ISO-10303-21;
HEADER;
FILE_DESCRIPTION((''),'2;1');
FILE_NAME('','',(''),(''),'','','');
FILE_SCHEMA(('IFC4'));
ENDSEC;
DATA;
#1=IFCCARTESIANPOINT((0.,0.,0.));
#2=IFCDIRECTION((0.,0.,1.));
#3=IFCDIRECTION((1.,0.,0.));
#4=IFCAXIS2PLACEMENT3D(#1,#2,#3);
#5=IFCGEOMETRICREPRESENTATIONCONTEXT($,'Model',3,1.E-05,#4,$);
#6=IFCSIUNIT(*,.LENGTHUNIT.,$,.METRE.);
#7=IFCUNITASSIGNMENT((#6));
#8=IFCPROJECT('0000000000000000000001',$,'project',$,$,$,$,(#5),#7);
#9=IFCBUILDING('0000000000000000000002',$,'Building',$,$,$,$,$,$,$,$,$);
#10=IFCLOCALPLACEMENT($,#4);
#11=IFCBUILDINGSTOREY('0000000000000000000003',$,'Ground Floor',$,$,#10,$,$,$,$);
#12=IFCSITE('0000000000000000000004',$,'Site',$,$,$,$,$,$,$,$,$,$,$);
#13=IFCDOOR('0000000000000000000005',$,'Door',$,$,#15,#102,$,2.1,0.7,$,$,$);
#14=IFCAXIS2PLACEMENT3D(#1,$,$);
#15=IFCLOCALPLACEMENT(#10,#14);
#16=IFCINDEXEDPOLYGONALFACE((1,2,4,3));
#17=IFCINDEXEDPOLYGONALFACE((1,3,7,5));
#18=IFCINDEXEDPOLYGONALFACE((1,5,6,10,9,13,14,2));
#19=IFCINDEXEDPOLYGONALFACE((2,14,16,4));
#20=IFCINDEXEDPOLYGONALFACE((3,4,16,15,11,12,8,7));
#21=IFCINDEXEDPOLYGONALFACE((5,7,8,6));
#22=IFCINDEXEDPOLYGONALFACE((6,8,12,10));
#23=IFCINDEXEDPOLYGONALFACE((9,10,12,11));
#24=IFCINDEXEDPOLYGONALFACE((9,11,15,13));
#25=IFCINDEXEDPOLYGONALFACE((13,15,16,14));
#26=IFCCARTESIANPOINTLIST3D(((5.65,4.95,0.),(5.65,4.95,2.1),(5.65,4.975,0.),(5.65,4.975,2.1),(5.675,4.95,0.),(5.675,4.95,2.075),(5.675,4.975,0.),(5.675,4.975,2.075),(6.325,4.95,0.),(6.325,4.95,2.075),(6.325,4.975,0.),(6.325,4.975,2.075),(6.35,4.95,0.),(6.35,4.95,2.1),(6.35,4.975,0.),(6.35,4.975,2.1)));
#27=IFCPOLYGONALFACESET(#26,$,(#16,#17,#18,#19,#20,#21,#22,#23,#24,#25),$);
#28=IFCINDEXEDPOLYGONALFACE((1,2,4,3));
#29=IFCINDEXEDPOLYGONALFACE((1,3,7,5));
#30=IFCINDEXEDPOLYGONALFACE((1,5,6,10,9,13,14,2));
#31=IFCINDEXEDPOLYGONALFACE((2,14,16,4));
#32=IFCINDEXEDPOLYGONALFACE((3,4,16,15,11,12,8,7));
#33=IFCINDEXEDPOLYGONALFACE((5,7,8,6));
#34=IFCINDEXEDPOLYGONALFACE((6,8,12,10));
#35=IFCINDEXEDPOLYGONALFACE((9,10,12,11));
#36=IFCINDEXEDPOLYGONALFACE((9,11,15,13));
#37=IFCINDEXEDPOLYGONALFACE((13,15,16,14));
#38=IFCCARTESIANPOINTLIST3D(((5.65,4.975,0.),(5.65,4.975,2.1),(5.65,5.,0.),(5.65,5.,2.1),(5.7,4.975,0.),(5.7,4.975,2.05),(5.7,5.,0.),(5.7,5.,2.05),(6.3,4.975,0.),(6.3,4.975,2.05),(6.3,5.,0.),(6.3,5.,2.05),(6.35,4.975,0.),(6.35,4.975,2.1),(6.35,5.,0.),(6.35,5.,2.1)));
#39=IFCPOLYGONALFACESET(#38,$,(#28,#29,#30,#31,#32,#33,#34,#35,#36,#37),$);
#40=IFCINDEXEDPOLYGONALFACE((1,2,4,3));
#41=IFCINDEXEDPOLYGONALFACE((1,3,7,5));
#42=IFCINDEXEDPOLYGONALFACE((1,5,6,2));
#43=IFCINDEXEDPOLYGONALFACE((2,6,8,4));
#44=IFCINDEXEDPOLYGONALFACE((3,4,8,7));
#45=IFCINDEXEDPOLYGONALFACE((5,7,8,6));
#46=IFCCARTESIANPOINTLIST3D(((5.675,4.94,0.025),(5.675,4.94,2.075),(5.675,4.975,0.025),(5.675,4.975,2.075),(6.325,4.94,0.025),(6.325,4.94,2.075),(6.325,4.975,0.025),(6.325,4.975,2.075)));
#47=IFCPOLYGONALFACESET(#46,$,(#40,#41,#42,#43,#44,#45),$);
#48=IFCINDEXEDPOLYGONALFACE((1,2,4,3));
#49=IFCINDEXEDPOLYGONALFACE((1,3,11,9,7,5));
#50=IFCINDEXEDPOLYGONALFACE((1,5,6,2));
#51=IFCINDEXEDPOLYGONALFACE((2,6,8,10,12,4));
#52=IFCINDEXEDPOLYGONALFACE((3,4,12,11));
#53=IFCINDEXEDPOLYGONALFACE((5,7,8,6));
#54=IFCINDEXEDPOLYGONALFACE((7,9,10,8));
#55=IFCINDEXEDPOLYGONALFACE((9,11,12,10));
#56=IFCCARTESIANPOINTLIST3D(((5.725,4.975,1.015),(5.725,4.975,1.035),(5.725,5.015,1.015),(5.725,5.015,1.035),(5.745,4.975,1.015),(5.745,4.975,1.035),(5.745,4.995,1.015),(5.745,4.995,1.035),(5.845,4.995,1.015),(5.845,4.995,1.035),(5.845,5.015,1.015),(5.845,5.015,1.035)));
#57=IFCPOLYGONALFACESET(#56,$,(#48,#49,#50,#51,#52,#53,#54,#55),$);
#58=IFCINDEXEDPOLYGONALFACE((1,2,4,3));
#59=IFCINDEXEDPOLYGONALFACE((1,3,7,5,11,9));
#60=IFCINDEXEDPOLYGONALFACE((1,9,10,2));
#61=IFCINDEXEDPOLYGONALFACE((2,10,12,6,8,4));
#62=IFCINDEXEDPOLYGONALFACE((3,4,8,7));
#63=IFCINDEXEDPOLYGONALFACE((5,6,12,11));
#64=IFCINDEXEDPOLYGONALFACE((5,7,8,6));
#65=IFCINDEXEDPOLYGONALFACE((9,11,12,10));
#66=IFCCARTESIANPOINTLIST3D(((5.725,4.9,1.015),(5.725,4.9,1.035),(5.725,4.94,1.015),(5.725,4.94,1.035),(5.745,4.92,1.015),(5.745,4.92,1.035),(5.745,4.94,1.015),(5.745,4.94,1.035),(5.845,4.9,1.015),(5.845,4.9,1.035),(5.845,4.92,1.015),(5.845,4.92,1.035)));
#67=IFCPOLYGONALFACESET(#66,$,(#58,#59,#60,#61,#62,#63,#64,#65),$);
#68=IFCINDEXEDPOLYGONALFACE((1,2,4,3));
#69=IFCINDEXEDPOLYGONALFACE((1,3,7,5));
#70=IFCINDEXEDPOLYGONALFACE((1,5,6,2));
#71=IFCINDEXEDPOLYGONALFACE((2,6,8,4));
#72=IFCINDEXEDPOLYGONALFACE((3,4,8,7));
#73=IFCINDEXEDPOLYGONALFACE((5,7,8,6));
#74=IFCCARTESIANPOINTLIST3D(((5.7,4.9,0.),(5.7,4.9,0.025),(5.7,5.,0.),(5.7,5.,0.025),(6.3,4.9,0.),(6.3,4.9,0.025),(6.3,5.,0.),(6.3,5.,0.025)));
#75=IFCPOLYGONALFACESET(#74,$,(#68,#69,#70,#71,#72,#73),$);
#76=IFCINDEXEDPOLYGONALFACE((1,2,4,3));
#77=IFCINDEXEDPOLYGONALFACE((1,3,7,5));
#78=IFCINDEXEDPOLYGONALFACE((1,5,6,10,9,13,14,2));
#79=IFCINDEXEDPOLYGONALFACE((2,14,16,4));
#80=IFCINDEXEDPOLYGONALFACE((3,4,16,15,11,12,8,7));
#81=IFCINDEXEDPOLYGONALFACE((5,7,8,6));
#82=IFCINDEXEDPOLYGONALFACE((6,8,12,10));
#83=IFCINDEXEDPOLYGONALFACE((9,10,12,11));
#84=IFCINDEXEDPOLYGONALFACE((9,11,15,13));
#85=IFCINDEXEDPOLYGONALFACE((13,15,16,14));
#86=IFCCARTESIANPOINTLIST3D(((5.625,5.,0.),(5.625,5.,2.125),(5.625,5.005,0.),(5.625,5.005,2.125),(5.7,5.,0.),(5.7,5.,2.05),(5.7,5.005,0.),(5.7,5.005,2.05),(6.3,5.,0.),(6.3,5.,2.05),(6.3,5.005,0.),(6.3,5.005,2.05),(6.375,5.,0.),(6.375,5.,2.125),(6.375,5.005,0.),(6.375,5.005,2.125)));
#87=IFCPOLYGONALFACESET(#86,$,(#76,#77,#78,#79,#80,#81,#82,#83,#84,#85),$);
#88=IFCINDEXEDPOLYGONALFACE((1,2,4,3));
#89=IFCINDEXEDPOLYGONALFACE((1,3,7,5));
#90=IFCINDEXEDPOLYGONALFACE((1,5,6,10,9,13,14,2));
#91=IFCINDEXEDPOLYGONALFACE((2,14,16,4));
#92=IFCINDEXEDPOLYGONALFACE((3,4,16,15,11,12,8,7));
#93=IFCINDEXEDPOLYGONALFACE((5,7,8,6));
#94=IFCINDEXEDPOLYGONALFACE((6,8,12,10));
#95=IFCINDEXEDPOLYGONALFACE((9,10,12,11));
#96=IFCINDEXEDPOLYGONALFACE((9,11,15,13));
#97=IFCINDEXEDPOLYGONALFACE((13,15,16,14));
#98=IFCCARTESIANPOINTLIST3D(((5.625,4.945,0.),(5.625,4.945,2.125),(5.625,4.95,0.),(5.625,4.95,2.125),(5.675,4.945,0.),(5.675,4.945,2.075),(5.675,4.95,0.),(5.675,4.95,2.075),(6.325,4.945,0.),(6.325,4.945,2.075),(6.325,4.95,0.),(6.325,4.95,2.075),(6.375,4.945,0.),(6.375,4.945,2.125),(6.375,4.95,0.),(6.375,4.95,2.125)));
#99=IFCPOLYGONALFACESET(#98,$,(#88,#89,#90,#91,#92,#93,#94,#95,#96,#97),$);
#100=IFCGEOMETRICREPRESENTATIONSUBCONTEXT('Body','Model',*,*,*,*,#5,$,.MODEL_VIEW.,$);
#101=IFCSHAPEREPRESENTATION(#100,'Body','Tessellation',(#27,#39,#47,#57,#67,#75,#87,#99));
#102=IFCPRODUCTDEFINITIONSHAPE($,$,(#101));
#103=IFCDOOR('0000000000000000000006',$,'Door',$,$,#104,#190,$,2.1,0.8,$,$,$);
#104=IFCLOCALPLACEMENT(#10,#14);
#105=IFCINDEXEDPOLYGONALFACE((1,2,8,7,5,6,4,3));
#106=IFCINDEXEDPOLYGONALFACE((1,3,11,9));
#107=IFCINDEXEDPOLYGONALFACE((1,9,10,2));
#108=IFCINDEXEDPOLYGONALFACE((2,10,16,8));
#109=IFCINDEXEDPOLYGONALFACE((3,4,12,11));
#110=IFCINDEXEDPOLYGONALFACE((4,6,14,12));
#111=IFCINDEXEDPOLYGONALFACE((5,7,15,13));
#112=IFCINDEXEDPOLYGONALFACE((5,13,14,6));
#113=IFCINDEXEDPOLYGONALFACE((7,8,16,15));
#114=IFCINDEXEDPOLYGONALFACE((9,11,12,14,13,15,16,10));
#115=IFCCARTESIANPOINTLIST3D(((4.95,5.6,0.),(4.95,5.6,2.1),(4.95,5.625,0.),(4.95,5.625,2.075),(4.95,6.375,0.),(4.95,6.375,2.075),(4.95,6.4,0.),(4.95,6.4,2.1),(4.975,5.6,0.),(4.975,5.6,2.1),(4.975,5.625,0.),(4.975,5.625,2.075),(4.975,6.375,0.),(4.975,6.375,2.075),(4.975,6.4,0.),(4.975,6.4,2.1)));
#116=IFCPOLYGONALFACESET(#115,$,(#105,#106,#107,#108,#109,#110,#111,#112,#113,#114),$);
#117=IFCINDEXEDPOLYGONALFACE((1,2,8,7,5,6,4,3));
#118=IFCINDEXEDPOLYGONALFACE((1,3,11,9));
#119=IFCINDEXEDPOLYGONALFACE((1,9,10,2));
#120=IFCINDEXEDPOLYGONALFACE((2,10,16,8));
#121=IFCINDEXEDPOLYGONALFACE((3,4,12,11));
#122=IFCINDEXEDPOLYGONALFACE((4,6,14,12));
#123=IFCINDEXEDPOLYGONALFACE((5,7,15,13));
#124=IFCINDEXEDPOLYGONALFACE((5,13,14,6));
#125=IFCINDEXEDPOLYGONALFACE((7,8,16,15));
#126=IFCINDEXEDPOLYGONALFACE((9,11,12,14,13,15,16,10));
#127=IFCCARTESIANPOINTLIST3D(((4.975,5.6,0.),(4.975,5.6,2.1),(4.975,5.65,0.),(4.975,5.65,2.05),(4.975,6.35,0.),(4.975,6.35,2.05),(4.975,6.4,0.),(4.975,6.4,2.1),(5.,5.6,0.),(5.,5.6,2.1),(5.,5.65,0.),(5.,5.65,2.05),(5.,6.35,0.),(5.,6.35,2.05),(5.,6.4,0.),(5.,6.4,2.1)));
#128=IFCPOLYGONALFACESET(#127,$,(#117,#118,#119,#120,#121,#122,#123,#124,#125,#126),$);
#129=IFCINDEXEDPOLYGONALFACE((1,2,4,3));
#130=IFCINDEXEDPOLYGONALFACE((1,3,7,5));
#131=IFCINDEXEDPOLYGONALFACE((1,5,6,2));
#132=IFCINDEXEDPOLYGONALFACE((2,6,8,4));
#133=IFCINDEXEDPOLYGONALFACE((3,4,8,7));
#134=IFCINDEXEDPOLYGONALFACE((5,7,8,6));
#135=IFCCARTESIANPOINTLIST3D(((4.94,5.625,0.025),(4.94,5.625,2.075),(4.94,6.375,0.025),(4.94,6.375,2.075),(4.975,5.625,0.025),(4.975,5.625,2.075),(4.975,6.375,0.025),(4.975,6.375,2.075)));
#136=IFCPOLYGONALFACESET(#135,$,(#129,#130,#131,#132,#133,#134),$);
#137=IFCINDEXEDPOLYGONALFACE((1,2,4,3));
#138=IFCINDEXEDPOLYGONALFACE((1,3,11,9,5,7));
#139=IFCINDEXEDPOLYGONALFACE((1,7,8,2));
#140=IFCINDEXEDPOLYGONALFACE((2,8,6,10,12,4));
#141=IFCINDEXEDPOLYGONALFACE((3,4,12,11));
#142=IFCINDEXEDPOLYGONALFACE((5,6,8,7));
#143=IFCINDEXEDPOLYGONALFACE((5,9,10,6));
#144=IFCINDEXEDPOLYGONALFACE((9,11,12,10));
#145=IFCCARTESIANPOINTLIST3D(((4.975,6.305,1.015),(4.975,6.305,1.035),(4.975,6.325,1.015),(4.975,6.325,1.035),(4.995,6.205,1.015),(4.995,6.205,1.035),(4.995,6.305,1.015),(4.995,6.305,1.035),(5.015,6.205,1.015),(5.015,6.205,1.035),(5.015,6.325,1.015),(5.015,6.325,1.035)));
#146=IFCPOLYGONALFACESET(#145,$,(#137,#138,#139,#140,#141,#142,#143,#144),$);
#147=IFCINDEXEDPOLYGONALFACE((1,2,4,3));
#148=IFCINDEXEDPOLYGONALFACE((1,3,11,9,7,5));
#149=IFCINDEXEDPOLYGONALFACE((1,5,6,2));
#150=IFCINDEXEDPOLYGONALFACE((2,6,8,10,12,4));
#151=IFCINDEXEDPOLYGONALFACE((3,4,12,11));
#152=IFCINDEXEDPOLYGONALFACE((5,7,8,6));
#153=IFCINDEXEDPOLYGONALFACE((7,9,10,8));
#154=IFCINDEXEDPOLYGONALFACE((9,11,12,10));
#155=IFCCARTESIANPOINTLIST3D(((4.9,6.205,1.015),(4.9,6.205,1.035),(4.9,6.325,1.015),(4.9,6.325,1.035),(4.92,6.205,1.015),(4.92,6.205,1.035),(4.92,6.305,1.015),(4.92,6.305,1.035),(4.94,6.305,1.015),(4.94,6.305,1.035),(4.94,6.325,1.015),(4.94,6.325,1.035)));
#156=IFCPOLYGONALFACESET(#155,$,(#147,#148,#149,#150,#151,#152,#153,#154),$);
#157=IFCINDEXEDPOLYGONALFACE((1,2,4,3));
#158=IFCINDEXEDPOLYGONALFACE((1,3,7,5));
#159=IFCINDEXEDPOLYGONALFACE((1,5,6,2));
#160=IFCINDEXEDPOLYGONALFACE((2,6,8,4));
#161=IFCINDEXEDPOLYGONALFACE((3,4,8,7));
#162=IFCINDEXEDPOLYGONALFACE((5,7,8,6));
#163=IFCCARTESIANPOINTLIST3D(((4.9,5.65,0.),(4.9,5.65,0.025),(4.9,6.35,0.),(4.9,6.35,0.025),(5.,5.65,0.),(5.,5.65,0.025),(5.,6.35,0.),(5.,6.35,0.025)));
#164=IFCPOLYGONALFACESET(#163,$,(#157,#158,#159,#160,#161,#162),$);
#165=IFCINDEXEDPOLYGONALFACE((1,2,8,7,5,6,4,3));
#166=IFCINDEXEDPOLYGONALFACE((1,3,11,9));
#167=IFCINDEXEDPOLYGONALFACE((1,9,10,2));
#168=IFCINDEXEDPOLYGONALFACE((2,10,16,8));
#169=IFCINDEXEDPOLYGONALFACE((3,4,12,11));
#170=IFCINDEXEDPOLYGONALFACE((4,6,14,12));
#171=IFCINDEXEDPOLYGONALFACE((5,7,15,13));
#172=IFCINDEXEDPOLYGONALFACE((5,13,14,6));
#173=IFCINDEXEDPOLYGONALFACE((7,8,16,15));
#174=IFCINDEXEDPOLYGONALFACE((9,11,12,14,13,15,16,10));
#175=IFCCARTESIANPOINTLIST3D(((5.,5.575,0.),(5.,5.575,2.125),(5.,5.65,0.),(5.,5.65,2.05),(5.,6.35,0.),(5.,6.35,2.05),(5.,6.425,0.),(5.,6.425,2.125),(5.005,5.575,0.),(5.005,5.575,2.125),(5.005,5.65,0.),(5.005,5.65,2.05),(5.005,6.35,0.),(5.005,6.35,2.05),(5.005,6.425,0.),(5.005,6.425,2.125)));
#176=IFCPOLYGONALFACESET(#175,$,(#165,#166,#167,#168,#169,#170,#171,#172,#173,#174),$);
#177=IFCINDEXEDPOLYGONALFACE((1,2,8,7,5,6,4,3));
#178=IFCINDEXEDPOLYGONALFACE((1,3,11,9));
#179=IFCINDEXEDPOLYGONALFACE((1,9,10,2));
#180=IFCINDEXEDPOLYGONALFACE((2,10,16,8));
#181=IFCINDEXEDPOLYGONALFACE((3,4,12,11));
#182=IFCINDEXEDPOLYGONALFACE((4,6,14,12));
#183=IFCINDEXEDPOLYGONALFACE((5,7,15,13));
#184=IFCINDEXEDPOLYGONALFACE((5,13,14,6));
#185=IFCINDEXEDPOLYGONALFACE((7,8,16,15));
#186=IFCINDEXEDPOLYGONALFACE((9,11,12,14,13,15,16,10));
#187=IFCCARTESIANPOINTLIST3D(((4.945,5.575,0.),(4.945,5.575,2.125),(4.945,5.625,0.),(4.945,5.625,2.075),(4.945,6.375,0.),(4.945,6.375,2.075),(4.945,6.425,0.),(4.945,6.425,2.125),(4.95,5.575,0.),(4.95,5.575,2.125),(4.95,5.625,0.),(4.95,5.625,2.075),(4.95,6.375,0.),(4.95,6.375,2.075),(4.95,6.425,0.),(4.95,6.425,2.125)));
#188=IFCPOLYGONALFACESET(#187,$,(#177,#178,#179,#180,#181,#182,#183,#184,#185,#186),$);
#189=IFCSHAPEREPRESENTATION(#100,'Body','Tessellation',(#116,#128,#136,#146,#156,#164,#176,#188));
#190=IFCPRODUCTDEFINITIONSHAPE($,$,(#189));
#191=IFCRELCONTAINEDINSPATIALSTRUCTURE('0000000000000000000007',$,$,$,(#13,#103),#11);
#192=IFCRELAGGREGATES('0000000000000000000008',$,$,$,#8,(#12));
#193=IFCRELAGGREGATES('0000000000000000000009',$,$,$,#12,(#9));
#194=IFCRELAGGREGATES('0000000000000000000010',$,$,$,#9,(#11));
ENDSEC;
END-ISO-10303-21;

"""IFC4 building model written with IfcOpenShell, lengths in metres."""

from ifc_helpers import new_model, si_unit, frame, origin_with_axes, place, context, subcontext, project, spatial, line, indexed_curve, outline, extrude, element, save


model = new_model("IFC4")

# Units and contexts
model_context = context("Model", 3, precision=1e-05, world=origin_with_axes())
body_context = subcontext(model_context, "Body", "Model", "MODEL_VIEW")
ifc_project = project(units=[si_unit("LENGTHUNIT", "METRE")], contexts=[model_context])

# Site, building, storey
site = spatial("IfcSite", under=ifc_project, Name="Site")
building = spatial("IfcBuilding", under=site, Name="Building")
storey_placement = place(None, origin_with_axes())
storey = spatial("IfcBuildingStorey", under=building, at=storey_placement, Name="Ground Floor")

# Doors
door_1_placement = place(storey_placement, frame((6.35, 5.0, 0.0), z_axis=(0.0, 0.0, 1.0), x_axis=(-1.0, 0.0, 0.0)))
element("IfcDoor", 1, at=door_1_placement, inside=storey, Name="Door", OverallHeight=2.1, OverallWidth=0.7, context=body_context, shape_type="SweptSolid", body=[
    extrude(outline(indexed_curve([(0.0, 0.0), (0.0, 2.1), (0.7, 2.1), (0.7, 0.0), (0.675, 0.0), (0.675, 2.075), (0.025, 2.075), (0.025, 0.0)], segments=[line(1, 2, 3, 4, 5, 6, 7, 8, 1)])), frame((0.0, 0.025, 0.0), z_axis=(0.0, -1.0, 0.0), x_axis=(1.0, 0.0, 0.0)), (0.0, 0.0, -1.0), 0.025),
    extrude(outline(indexed_curve([(0.0, 0.0), (0.0, 2.1), (0.7, 2.1), (0.7, 0.0), (0.65, 0.0), (0.65, 2.05), (0.05, 2.05), (0.05, 0.0)], segments=[line(1, 2, 3, 4, 5, 6, 7, 8, 1)])), frame((0.0, 0.0, 0.0), z_axis=(0.0, -1.0, 0.0), x_axis=(1.0, 0.0, 0.0)), (0.0, 0.0, -1.0), 0.025),
    extrude(outline(indexed_curve([(0.0, 0.0), (0.65, 0.0), (0.65, 0.035), (0.0, 0.035)], segments=[line(1, 2, 3, 4, 1)])), frame((0.025, 0.025, 0.025), z_axis=(0.0, 0.0, 1.0), x_axis=(1.0, 0.0, 0.0)), (0.0, 0.0, 1.0), 2.05),
    extrude(outline(indexed_curve([(0.0, 0.0), (0.0, -0.04), (-0.12, -0.04), (-0.12, -0.02), (-0.02, -0.02), (-0.02, 0.0)], segments=[line(1, 2, 3, 4, 5, 6, 1)])), frame((0.625, 0.025, 1.015), z_axis=(0.0, 0.0, 1.0), x_axis=(1.0, 0.0, 0.0)), (0.0, 0.0, 1.0), 0.02),
    extrude(outline(indexed_curve([(0.0, 0.0), (0.0, 0.04), (-0.12, 0.04), (-0.12, 0.02), (-0.02, 0.02), (-0.02, 0.0)], segments=[line(1, 2, 3, 4, 5, 6, 1)])), frame((0.625, 0.06, 1.015), z_axis=(0.0, 0.0, 1.0), x_axis=(1.0, 0.0, 0.0)), (0.0, 0.0, 1.0), 0.02),
    extrude(outline(indexed_curve([(0.0, 0.0), (0.6, 0.0), (0.6, 0.1), (0.0, 0.1)], segments=[line(1, 2, 3, 4, 1)])), frame((0.05, 0.0, 0.0), z_axis=(0.0, 0.0, 1.0), x_axis=(1.0, 0.0, 0.0)), (0.0, 0.0, 1.0), 0.025),
    extrude(outline(indexed_curve([(0.0, 0.0), (0.0, 2.125), (0.75, 2.125), (0.75, 0.0), (0.675, 0.0), (0.675, 2.05), (0.075, 2.05), (0.075, 0.0)], segments=[line(1, 2, 3, 4, 5, 6, 7, 8, 1)])), frame((-0.025, -0.005, 0.0), z_axis=(0.0, -1.0, 0.0), x_axis=(1.0, 0.0, 0.0)), (0.0, 0.0, -1.0), 0.005),
    extrude(outline(indexed_curve([(0.0, 0.0), (0.0, 2.125), (0.75, 2.125), (0.75, 0.0), (0.7, 0.0), (0.7, 2.075), (0.05, 2.075), (0.05, 0.0)], segments=[line(1, 2, 3, 4, 5, 6, 7, 8, 1)])), frame((-0.025, 0.05, 0.0), z_axis=(0.0, -1.0, 0.0), x_axis=(1.0, 0.0, 0.0)), (0.0, 0.0, -1.0), 0.005),
])
door_2_placement = place(storey_placement, frame((5.0, 5.6, 0.0), z_axis=(0.0, 0.0, 1.0), x_axis=(0.0, 1.0, 0.0)))
element("IfcDoor", 2, at=door_2_placement, inside=storey, Name="Door", OverallHeight=2.1, OverallWidth=0.8, context=body_context, shape_type="SweptSolid", body=[
    extrude(outline(indexed_curve([(0.0, 0.0), (0.0, 2.1), (0.8, 2.1), (0.8, 0.0), (0.775, 0.0), (0.775, 2.075), (0.025, 2.075), (0.025, 0.0)], segments=[line(1, 2, 3, 4, 5, 6, 7, 8, 1)])), frame((0.0, 0.025, 0.0), z_axis=(0.0, -1.0, 0.0), x_axis=(1.0, 0.0, 0.0)), (0.0, 0.0, -1.0), 0.025),
    extrude(outline(indexed_curve([(0.0, 0.0), (0.0, 2.1), (0.8, 2.1), (0.8, 0.0), (0.75, 0.0), (0.75, 2.05), (0.05, 2.05), (0.05, 0.0)], segments=[line(1, 2, 3, 4, 5, 6, 7, 8, 1)])), frame((0.0, 0.0, 0.0), z_axis=(0.0, -1.0, 0.0), x_axis=(1.0, 0.0, 0.0)), (0.0, 0.0, -1.0), 0.025),
    extrude(outline(indexed_curve([(0.0, 0.0), (0.75, 0.0), (0.75, 0.035), (0.0, 0.035)], segments=[line(1, 2, 3, 4, 1)])), frame((0.025, 0.025, 0.025), z_axis=(0.0, 0.0, 1.0), x_axis=(1.0, 0.0, 0.0)), (0.0, 0.0, 1.0), 2.05),
    extrude(outline(indexed_curve([(0.0, 0.0), (0.0, -0.04), (-0.12, -0.04), (-0.12, -0.02), (-0.02, -0.02), (-0.02, 0.0)], segments=[line(1, 2, 3, 4, 5, 6, 1)])), frame((0.725, 0.025, 1.015), z_axis=(0.0, 0.0, 1.0), x_axis=(1.0, 0.0, 0.0)), (0.0, 0.0, 1.0), 0.02),
    extrude(outline(indexed_curve([(0.0, 0.0), (0.0, 0.04), (-0.12, 0.04), (-0.12, 0.02), (-0.02, 0.02), (-0.02, 0.0)], segments=[line(1, 2, 3, 4, 5, 6, 1)])), frame((0.725, 0.06, 1.015), z_axis=(0.0, 0.0, 1.0), x_axis=(1.0, 0.0, 0.0)), (0.0, 0.0, 1.0), 0.02),
    extrude(outline(indexed_curve([(0.0, 0.0), (0.7, 0.0), (0.7, 0.1), (0.0, 0.1)], segments=[line(1, 2, 3, 4, 1)])), frame((0.05, 0.0, 0.0), z_axis=(0.0, 0.0, 1.0), x_axis=(1.0, 0.0, 0.0)), (0.0, 0.0, 1.0), 0.025),
    extrude(outline(indexed_curve([(0.0, 0.0), (0.0, 2.125), (0.85, 2.125), (0.85, 0.0), (0.775, 0.0), (0.775, 2.05), (0.075, 2.05), (0.075, 0.0)], segments=[line(1, 2, 3, 4, 5, 6, 7, 8, 1)])), frame((-0.025, -0.005, 0.0), z_axis=(0.0, -1.0, 0.0), x_axis=(1.0, 0.0, 0.0)), (0.0, 0.0, -1.0), 0.005),
    extrude(outline(indexed_curve([(0.0, 0.0), (0.0, 2.125), (0.85, 2.125), (0.85, 0.0), (0.8, 0.0), (0.8, 2.075), (0.05, 2.075), (0.05, 0.0)], segments=[line(1, 2, 3, 4, 5, 6, 7, 8, 1)])), frame((-0.025, 0.05, 0.0), z_axis=(0.0, -1.0, 0.0), x_axis=(1.0, 0.0, 0.0)), (0.0, 0.0, -1.0), 0.005),
])

save(model, "model.ifc")
